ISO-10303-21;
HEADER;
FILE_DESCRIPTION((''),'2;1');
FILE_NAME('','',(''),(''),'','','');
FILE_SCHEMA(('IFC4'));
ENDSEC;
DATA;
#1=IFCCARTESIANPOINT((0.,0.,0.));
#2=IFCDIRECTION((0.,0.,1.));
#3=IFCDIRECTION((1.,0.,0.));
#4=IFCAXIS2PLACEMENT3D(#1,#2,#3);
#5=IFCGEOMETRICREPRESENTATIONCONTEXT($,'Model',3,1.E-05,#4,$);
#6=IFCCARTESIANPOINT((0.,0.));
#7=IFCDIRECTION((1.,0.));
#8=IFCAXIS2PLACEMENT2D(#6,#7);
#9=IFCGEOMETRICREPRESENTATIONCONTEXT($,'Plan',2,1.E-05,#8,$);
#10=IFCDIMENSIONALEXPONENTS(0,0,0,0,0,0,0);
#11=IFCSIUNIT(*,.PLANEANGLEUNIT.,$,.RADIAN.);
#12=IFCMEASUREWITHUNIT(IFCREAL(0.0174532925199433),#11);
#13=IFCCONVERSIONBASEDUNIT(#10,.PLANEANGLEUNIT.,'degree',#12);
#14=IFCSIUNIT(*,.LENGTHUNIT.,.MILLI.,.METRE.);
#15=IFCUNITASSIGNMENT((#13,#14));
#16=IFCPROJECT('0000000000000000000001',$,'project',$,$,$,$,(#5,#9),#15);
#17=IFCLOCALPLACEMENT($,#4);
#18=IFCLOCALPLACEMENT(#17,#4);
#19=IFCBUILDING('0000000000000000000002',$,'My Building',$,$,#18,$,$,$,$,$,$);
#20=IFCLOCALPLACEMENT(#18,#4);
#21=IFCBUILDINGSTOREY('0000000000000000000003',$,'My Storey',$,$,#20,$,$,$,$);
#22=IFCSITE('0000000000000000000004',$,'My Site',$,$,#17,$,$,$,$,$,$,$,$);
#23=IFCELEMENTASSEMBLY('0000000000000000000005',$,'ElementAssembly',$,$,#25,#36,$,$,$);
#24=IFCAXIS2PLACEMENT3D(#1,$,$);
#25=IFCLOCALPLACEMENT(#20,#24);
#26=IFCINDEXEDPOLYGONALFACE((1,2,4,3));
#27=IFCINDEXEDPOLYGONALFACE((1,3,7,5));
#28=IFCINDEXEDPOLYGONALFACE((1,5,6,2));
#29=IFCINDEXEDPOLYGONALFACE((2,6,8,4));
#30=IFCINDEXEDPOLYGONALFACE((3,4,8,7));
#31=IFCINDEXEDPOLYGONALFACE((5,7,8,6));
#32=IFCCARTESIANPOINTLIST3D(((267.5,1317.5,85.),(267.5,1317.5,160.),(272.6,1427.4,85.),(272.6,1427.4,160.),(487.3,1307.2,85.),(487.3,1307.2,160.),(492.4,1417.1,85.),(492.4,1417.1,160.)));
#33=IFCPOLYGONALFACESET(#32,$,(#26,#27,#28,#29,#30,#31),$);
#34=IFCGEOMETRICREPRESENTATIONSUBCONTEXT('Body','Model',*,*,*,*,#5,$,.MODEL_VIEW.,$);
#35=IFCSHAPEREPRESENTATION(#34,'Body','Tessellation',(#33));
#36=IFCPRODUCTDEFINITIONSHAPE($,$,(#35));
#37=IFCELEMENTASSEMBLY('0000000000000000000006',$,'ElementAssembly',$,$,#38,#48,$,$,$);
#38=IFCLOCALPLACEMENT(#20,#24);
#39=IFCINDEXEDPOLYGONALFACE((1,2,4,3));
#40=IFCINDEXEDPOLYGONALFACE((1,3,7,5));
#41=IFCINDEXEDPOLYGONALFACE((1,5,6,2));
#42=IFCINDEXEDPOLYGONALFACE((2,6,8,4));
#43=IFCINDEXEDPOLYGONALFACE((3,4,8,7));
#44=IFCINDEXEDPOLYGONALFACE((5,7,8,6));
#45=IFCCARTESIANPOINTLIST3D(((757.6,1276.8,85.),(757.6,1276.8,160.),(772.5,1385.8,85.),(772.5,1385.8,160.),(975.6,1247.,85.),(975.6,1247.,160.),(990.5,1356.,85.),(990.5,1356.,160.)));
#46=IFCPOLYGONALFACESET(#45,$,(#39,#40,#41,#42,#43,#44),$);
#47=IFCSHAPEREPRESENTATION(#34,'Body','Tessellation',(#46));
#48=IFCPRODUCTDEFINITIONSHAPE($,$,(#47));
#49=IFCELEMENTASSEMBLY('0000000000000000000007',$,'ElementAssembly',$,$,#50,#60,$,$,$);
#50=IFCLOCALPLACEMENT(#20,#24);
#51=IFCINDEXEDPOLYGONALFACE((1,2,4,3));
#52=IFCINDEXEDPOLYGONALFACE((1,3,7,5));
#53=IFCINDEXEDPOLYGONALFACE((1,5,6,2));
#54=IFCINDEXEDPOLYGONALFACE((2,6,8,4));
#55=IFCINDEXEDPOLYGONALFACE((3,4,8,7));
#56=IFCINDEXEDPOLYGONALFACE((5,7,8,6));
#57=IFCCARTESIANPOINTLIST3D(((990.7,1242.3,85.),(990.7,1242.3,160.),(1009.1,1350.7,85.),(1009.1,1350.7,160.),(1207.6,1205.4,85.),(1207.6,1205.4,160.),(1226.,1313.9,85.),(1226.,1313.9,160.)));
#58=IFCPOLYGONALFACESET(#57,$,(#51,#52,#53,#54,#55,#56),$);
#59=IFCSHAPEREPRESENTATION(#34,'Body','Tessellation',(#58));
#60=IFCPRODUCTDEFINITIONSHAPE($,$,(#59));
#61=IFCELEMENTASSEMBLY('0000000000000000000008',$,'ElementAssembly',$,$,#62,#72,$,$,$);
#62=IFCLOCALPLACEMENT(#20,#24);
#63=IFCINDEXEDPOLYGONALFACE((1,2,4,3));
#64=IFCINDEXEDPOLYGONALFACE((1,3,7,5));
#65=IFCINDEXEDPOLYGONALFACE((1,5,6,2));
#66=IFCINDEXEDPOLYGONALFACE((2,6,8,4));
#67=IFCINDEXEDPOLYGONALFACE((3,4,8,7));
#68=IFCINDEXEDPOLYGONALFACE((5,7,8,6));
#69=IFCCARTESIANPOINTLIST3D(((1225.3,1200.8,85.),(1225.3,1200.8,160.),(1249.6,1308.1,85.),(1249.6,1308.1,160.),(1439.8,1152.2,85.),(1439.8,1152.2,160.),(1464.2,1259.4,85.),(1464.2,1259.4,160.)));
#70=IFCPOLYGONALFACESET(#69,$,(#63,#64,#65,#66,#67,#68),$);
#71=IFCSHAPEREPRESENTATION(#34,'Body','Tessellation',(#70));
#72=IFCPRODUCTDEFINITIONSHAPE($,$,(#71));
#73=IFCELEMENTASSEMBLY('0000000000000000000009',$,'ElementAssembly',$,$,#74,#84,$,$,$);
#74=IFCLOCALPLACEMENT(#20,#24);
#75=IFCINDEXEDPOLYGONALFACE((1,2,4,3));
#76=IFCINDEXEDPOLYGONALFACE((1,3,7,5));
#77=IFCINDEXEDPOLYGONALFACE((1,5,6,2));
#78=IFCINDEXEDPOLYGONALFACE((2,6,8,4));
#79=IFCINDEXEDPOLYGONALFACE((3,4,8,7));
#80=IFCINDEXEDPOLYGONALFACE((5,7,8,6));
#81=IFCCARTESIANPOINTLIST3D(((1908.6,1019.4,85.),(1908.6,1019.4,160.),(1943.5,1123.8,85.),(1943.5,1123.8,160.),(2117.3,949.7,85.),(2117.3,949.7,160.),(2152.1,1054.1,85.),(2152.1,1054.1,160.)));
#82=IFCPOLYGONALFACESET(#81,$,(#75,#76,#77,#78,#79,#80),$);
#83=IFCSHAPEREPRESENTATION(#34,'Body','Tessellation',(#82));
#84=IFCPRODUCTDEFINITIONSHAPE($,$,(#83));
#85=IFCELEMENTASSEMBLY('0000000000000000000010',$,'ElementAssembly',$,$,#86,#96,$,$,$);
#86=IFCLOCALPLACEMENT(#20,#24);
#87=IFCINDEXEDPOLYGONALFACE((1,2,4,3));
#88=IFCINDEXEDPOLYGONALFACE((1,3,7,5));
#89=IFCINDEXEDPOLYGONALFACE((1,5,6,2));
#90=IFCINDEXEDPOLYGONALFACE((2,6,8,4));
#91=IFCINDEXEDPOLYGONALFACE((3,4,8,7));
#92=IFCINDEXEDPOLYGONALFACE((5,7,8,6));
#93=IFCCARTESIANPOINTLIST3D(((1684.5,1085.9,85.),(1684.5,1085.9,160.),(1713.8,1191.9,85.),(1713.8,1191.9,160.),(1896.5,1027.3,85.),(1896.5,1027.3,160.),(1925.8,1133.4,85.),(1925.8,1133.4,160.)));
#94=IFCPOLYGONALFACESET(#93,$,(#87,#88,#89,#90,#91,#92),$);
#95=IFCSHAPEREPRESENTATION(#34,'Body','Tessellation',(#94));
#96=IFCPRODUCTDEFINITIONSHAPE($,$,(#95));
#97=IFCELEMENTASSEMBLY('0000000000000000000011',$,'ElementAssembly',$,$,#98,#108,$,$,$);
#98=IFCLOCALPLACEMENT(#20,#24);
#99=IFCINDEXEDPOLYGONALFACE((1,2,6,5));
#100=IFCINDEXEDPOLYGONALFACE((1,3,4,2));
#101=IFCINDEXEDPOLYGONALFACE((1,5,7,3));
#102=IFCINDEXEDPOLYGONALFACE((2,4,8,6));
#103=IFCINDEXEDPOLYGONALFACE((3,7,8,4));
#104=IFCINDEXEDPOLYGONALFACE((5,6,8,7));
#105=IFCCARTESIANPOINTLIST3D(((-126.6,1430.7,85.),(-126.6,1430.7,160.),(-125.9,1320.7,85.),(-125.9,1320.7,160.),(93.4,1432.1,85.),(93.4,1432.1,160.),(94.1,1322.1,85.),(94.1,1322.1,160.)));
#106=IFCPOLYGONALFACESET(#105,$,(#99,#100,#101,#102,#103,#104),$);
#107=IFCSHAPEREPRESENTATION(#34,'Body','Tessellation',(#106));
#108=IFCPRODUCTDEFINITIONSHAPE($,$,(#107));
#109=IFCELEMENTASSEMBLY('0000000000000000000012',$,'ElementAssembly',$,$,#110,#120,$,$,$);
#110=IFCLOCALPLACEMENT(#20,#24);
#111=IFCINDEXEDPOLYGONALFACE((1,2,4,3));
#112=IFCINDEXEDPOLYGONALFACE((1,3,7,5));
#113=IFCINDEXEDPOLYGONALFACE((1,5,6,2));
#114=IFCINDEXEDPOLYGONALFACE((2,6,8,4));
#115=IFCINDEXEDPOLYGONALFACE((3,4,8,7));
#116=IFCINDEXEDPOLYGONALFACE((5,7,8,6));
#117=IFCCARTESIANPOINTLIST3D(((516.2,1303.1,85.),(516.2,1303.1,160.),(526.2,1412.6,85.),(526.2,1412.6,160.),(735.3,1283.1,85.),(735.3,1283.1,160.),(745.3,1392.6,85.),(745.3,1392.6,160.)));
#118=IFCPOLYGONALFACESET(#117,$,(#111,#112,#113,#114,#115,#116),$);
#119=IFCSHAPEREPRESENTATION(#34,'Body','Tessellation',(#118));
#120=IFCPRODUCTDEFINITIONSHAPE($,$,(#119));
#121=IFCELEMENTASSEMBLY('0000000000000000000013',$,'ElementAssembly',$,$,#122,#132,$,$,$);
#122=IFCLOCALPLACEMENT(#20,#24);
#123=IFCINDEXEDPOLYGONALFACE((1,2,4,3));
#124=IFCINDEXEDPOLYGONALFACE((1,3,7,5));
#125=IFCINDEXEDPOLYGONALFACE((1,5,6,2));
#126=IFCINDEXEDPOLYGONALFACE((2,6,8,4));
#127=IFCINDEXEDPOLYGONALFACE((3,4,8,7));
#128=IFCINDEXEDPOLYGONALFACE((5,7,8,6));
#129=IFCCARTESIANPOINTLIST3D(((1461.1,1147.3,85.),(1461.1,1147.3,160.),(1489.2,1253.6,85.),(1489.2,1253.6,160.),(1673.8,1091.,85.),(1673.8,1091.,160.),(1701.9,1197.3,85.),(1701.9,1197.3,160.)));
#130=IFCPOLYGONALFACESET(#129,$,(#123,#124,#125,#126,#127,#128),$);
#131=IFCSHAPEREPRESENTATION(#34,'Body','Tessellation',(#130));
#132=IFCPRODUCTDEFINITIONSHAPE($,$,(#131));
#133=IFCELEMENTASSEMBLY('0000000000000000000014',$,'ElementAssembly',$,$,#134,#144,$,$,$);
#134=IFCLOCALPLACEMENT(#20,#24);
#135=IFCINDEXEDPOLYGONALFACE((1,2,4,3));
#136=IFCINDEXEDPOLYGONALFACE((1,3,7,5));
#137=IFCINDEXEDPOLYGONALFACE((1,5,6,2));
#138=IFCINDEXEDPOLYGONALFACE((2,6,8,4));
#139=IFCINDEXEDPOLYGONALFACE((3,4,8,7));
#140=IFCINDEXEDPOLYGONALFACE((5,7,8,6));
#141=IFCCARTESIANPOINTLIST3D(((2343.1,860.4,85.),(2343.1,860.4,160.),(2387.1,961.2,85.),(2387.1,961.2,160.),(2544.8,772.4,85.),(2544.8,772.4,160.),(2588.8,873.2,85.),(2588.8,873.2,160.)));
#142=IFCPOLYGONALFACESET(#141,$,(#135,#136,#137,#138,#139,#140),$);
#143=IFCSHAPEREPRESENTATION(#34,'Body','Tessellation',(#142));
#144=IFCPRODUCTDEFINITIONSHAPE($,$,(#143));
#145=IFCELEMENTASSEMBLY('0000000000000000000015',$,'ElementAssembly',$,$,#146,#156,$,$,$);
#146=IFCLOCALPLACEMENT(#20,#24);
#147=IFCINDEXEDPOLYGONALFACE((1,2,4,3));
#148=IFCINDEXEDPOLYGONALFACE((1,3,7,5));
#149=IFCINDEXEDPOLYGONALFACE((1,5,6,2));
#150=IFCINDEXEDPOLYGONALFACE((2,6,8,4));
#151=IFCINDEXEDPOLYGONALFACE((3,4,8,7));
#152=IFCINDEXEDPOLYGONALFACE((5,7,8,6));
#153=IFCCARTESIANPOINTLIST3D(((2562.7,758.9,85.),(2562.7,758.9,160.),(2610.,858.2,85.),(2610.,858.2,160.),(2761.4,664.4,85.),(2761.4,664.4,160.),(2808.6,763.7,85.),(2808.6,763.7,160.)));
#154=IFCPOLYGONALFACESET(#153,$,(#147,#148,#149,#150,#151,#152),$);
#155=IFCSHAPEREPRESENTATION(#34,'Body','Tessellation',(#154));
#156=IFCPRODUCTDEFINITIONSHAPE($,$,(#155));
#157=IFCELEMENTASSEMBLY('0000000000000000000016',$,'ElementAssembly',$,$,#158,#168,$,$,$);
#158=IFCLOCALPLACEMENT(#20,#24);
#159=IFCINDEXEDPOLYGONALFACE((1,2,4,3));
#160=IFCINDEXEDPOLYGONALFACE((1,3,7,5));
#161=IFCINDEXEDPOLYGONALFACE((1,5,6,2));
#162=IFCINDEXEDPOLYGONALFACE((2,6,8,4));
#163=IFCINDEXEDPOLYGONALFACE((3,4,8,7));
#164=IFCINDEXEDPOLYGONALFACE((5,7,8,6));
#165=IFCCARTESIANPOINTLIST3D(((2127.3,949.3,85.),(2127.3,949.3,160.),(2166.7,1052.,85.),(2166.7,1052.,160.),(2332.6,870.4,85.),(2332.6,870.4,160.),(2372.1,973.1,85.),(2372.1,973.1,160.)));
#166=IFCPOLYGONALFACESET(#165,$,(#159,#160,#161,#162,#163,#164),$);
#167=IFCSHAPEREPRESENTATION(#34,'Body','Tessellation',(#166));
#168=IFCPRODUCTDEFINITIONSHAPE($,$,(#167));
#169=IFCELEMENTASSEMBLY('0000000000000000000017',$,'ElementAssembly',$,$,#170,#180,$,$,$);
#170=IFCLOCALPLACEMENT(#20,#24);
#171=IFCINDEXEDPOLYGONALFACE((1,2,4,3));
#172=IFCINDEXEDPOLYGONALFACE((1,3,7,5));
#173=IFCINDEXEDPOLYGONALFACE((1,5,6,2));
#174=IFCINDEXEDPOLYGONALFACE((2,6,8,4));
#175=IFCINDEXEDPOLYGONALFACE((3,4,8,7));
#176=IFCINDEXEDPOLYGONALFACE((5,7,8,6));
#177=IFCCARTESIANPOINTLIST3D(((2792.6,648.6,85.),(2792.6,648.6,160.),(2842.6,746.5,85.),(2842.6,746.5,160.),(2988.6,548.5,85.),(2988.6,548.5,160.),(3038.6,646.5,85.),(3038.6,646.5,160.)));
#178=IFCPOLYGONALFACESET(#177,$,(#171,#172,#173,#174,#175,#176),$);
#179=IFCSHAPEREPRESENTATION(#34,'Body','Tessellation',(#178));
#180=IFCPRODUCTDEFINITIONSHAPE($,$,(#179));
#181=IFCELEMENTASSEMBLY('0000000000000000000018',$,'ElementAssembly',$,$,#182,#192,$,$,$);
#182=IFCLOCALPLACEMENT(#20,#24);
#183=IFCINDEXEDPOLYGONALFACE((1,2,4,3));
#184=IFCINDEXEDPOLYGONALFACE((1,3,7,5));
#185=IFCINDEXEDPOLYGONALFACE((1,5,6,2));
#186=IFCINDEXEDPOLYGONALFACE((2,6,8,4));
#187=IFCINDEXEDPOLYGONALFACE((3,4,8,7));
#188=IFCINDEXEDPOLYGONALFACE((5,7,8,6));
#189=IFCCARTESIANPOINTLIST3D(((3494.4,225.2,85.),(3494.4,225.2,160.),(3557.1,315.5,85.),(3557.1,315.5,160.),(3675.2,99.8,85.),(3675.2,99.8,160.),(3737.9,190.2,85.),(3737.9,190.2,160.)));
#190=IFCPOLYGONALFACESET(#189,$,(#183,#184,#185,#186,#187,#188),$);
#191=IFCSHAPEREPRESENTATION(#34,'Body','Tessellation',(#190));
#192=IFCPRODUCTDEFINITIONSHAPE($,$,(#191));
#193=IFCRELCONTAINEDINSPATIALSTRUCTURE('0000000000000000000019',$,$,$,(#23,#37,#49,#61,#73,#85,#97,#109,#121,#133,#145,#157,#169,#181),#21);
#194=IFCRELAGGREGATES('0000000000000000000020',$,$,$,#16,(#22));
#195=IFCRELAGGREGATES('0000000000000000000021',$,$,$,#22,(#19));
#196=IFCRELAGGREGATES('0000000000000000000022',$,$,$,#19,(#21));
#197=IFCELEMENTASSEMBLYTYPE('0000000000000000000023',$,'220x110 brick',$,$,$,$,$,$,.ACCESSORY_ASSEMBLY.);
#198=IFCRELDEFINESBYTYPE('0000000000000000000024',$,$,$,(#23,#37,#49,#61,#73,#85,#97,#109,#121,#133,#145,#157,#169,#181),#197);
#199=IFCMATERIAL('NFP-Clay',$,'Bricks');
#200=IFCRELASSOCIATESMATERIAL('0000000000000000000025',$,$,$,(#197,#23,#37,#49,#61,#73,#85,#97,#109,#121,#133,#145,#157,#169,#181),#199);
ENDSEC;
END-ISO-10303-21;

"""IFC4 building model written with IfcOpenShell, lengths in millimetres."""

from ifc_helpers import new_model, entity, si_unit, converted_unit, frame, origin_with_axes, origin_2d_with_axis, place, context, subcontext, project, spatial, rectangle, extrude, material, material_profile, profile_set, profile_usage, type_object, element, save


model = new_model("IFC4")

# Units and contexts
model_context = context("Model", 3, precision=1e-05, world=origin_with_axes())
plan_context = context("Plan", 2, precision=1e-05, world=origin_2d_with_axis())
body_context = subcontext(model_context, "Body", "Model", "MODEL_VIEW")
ifc_project = project(units=[converted_unit("PLANEANGLEUNIT", "degree", entity("IfcReal", 0.0174532925199433), si_unit("PLANEANGLEUNIT", "RADIAN"), dimensions=[0, 0, 0, 0, 0, 0, 0]), si_unit("LENGTHUNIT", "METRE", prefix="MILLI")], contexts=[model_context, plan_context])

# Site, building, storey
site_placement = place(None, origin_with_axes())
site = spatial("IfcSite", under=ifc_project, at=site_placement, Name="My Site")
building_placement = place(site_placement, origin_with_axes())
building = spatial("IfcBuilding", under=site, at=building_placement, Name="My Building")
storey_placement = place(building_placement, origin_with_axes())
storey = spatial("IfcBuildingStorey", under=building, at=storey_placement, Name="My Storey")

# Element assemblies
ifc_material_1 = material(Name="NFP-Clay", Category="Bricks")
ifc_material_profile_1 = material_profile(ifc_material_1, rectangle(XDim=220.0, YDim=110.0))
ifc_profile_set_1 = profile_set([ifc_material_profile_1])
ifc_profile_usage_1 = profile_usage(ifc_profile_set_1, cardinal=5)
element_assembly_type_1 = type_object("IfcElementAssemblyType", Name="220x110 brick", PredefinedType="ACCESSORY_ASSEMBLY", material=ifc_profile_set_1)
assembly_1_placement = place(storey_placement, frame((379.9, 1367.3, 85.0), z_axis=(0.0, 0.0, 1.0), x_axis=(0.998912, -0.046635, 0.0)))
element("IfcElementAssembly", 1, at=assembly_1_placement, inside=storey, type_object=element_assembly_type_1, material=ifc_profile_usage_1, Name="ElementAssembly", context=body_context, shape_type="SweptSolid", body=[
    extrude(rectangle(XDim=220.0, YDim=110.0), origin_with_axes(), (0.0, 0.0, 1.0), 75.0),
])
ifc_profile_usage_2 = profile_usage(ifc_profile_set_1, cardinal=5)
assembly_2_placement = place(storey_placement, frame((874.0, 1316.4, 85.0), z_axis=(0.0, 0.0, 1.0), x_axis=(0.990803, -0.135315, 0.0)))
element("IfcElementAssembly", 2, at=assembly_2_placement, inside=storey, type_object=element_assembly_type_1, material=ifc_profile_usage_2, Name="ElementAssembly", context=body_context, shape_type="SweptSolid", body=[
    extrude(rectangle(XDim=220.0, YDim=110.0), origin_with_axes(), (0.0, 0.0, 1.0), 75.0),
])
ifc_profile_usage_3 = profile_usage(ifc_profile_set_1, cardinal=5)
assembly_3_placement = place(storey_placement, frame((1108.3, 1278.1, 85.0), z_axis=(0.0, 0.0, 1.0), x_axis=(0.985858, -0.167581, 0.0)))
element("IfcElementAssembly", 3, at=assembly_3_placement, inside=storey, type_object=element_assembly_type_1, material=ifc_profile_usage_3, Name="ElementAssembly", context=body_context, shape_type="SweptSolid", body=[
    extrude(rectangle(XDim=220.0, YDim=110.0), origin_with_axes(), (0.0, 0.0, 1.0), 75.0),
])
ifc_profile_usage_4 = profile_usage(ifc_profile_set_1, cardinal=5)
assembly_4_placement = place(storey_placement, frame((1344.7, 1230.1, 85.0), z_axis=(0.0, 0.0, 1.0), x_axis=(0.975238, -0.22116, 0.0)))
element("IfcElementAssembly", 4, at=assembly_4_placement, inside=storey, type_object=element_assembly_type_1, material=ifc_profile_usage_4, Name="ElementAssembly", context=body_context, shape_type="SweptSolid", body=[
    extrude(rectangle(XDim=220.0, YDim=110.0), origin_with_axes(), (0.0, 0.0, 1.0), 75.0),
])
ifc_profile_usage_5 = profile_usage(ifc_profile_set_1, cardinal=5)
assembly_5_placement = place(storey_placement, frame((2030.4, 1036.8, 85.0), z_axis=(0.0, 0.0, 1.0), x_axis=(0.948488, -0.316814, 0.0)))
element("IfcElementAssembly", 5, at=assembly_5_placement, inside=storey, type_object=element_assembly_type_1, material=ifc_profile_usage_5, Name="ElementAssembly", context=body_context, shape_type="SweptSolid", body=[
    extrude(rectangle(XDim=220.0, YDim=110.0), origin_with_axes(), (0.0, 0.0, 1.0), 75.0),
])
ifc_profile_usage_6 = profile_usage(ifc_profile_set_1, cardinal=5)
assembly_6_placement = place(storey_placement, frame((1805.1, 1109.6, 85.0), z_axis=(0.0, 0.0, 1.0), x_axis=(0.963913, -0.266217, 0.0)))
element("IfcElementAssembly", 6, at=assembly_6_placement, inside=storey, type_object=element_assembly_type_1, material=ifc_profile_usage_6, Name="ElementAssembly", context=body_context, shape_type="SweptSolid", body=[
    extrude(rectangle(XDim=220.0, YDim=110.0), origin_with_axes(), (0.0, 0.0, 1.0), 75.0),
])
ifc_profile_usage_7 = profile_usage(ifc_profile_set_1, cardinal=5)
assembly_7_placement = place(storey_placement, frame((-16.3, 1376.4, 85.0), z_axis=(0.0, 0.0, 1.0), x_axis=(0.99998, 0.006251, 0.0)))
element("IfcElementAssembly", 7, at=assembly_7_placement, inside=storey, type_object=element_assembly_type_1, material=ifc_profile_usage_7, Name="ElementAssembly", context=body_context, shape_type="SweptSolid", body=[
    extrude(rectangle(XDim=220.0, YDim=110.0), origin_with_axes(), (0.0, 0.0, 1.0), 75.0),
])
ifc_profile_usage_8 = profile_usage(ifc_profile_set_1, cardinal=5)
assembly_8_placement = place(storey_placement, frame((630.8, 1347.9, 85.0), z_axis=(0.0, 0.0, 1.0), x_axis=(0.995855, -0.090953, 0.0)))
element("IfcElementAssembly", 8, at=assembly_8_placement, inside=storey, type_object=element_assembly_type_1, material=ifc_profile_usage_8, Name="ElementAssembly", context=body_context, shape_type="SweptSolid", body=[
    extrude(rectangle(XDim=220.0, YDim=110.0), origin_with_axes(), (0.0, 0.0, 1.0), 75.0),
])
ifc_profile_usage_9 = profile_usage(ifc_profile_set_1, cardinal=5)
assembly_9_placement = place(storey_placement, frame((1581.5, 1172.3, 85.0), z_axis=(0.0, 0.0, 1.0), x_axis=(0.966698, -0.25592, 0.0)))
element("IfcElementAssembly", 9, at=assembly_9_placement, inside=storey, type_object=element_assembly_type_1, material=ifc_profile_usage_9, Name="ElementAssembly", context=body_context, shape_type="SweptSolid", body=[
    extrude(rectangle(XDim=220.0, YDim=110.0), origin_with_axes(), (0.0, 0.0, 1.0), 75.0),
])
ifc_profile_usage_10 = profile_usage(ifc_profile_set_1, cardinal=5)
assembly_10_placement = place(storey_placement, frame((2466.0, 866.8, 85.0), z_axis=(0.0, 0.0, 1.0), x_axis=(0.916542, -0.399938, 0.0)))
element("IfcElementAssembly", 10, at=assembly_10_placement, inside=storey, type_object=element_assembly_type_1, material=ifc_profile_usage_10, Name="ElementAssembly", context=body_context, shape_type="SweptSolid", body=[
    extrude(rectangle(XDim=220.0, YDim=110.0), origin_with_axes(), (0.0, 0.0, 1.0), 75.0),
])
ifc_profile_usage_11 = profile_usage(ifc_profile_set_1, cardinal=5)
assembly_11_placement = place(storey_placement, frame((2685.7, 761.3, 85.0), z_axis=(0.0, 0.0, 1.0), x_axis=(0.903001, -0.429639, 0.0)))
element("IfcElementAssembly", 11, at=assembly_11_placement, inside=storey, type_object=element_assembly_type_1, material=ifc_profile_usage_11, Name="ElementAssembly", context=body_context, shape_type="SweptSolid", body=[
    extrude(rectangle(XDim=220.0, YDim=110.0), origin_with_axes(), (0.0, 0.0, 1.0), 75.0),
])
ifc_profile_usage_12 = profile_usage(ifc_profile_set_1, cardinal=5)
assembly_12_placement = place(storey_placement, frame((2249.7, 961.2, 85.0), z_axis=(0.0, 0.0, 1.0), x_axis=(0.933481, -0.358627, 0.0)))
element("IfcElementAssembly", 12, at=assembly_12_placement, inside=storey, type_object=element_assembly_type_1, material=ifc_profile_usage_12, Name="ElementAssembly", context=body_context, shape_type="SweptSolid", body=[
    extrude(rectangle(XDim=220.0, YDim=110.0), origin_with_axes(), (0.0, 0.0, 1.0), 75.0),
])
ifc_profile_usage_13 = profile_usage(ifc_profile_set_1, cardinal=5)
assembly_13_placement = place(storey_placement, frame((2915.6, 647.5, 85.0), z_axis=(0.0, 0.0, 1.0), x_axis=(0.890691, -0.45461, 0.0)))
element("IfcElementAssembly", 13, at=assembly_13_placement, inside=storey, type_object=element_assembly_type_1, material=ifc_profile_usage_13, Name="ElementAssembly", context=body_context, shape_type="SweptSolid", body=[
    extrude(rectangle(XDim=220.0, YDim=110.0), origin_with_axes(), (0.0, 0.0, 1.0), 75.0),
])
ifc_profile_usage_14 = profile_usage(ifc_profile_set_1, cardinal=5)
assembly_14_placement = place(storey_placement, frame((3616.2, 207.7, 85.0), z_axis=(0.0, 0.0, 1.0), x_axis=(0.82177, -0.569819, 0.0)))
element("IfcElementAssembly", 14, at=assembly_14_placement, inside=storey, type_object=element_assembly_type_1, material=ifc_profile_usage_14, Name="ElementAssembly", context=body_context, shape_type="SweptSolid", body=[
    extrude(rectangle(XDim=220.0, YDim=110.0), origin_with_axes(), (0.0, 0.0, 1.0), 75.0),
])

save(model, "model.ifc")
